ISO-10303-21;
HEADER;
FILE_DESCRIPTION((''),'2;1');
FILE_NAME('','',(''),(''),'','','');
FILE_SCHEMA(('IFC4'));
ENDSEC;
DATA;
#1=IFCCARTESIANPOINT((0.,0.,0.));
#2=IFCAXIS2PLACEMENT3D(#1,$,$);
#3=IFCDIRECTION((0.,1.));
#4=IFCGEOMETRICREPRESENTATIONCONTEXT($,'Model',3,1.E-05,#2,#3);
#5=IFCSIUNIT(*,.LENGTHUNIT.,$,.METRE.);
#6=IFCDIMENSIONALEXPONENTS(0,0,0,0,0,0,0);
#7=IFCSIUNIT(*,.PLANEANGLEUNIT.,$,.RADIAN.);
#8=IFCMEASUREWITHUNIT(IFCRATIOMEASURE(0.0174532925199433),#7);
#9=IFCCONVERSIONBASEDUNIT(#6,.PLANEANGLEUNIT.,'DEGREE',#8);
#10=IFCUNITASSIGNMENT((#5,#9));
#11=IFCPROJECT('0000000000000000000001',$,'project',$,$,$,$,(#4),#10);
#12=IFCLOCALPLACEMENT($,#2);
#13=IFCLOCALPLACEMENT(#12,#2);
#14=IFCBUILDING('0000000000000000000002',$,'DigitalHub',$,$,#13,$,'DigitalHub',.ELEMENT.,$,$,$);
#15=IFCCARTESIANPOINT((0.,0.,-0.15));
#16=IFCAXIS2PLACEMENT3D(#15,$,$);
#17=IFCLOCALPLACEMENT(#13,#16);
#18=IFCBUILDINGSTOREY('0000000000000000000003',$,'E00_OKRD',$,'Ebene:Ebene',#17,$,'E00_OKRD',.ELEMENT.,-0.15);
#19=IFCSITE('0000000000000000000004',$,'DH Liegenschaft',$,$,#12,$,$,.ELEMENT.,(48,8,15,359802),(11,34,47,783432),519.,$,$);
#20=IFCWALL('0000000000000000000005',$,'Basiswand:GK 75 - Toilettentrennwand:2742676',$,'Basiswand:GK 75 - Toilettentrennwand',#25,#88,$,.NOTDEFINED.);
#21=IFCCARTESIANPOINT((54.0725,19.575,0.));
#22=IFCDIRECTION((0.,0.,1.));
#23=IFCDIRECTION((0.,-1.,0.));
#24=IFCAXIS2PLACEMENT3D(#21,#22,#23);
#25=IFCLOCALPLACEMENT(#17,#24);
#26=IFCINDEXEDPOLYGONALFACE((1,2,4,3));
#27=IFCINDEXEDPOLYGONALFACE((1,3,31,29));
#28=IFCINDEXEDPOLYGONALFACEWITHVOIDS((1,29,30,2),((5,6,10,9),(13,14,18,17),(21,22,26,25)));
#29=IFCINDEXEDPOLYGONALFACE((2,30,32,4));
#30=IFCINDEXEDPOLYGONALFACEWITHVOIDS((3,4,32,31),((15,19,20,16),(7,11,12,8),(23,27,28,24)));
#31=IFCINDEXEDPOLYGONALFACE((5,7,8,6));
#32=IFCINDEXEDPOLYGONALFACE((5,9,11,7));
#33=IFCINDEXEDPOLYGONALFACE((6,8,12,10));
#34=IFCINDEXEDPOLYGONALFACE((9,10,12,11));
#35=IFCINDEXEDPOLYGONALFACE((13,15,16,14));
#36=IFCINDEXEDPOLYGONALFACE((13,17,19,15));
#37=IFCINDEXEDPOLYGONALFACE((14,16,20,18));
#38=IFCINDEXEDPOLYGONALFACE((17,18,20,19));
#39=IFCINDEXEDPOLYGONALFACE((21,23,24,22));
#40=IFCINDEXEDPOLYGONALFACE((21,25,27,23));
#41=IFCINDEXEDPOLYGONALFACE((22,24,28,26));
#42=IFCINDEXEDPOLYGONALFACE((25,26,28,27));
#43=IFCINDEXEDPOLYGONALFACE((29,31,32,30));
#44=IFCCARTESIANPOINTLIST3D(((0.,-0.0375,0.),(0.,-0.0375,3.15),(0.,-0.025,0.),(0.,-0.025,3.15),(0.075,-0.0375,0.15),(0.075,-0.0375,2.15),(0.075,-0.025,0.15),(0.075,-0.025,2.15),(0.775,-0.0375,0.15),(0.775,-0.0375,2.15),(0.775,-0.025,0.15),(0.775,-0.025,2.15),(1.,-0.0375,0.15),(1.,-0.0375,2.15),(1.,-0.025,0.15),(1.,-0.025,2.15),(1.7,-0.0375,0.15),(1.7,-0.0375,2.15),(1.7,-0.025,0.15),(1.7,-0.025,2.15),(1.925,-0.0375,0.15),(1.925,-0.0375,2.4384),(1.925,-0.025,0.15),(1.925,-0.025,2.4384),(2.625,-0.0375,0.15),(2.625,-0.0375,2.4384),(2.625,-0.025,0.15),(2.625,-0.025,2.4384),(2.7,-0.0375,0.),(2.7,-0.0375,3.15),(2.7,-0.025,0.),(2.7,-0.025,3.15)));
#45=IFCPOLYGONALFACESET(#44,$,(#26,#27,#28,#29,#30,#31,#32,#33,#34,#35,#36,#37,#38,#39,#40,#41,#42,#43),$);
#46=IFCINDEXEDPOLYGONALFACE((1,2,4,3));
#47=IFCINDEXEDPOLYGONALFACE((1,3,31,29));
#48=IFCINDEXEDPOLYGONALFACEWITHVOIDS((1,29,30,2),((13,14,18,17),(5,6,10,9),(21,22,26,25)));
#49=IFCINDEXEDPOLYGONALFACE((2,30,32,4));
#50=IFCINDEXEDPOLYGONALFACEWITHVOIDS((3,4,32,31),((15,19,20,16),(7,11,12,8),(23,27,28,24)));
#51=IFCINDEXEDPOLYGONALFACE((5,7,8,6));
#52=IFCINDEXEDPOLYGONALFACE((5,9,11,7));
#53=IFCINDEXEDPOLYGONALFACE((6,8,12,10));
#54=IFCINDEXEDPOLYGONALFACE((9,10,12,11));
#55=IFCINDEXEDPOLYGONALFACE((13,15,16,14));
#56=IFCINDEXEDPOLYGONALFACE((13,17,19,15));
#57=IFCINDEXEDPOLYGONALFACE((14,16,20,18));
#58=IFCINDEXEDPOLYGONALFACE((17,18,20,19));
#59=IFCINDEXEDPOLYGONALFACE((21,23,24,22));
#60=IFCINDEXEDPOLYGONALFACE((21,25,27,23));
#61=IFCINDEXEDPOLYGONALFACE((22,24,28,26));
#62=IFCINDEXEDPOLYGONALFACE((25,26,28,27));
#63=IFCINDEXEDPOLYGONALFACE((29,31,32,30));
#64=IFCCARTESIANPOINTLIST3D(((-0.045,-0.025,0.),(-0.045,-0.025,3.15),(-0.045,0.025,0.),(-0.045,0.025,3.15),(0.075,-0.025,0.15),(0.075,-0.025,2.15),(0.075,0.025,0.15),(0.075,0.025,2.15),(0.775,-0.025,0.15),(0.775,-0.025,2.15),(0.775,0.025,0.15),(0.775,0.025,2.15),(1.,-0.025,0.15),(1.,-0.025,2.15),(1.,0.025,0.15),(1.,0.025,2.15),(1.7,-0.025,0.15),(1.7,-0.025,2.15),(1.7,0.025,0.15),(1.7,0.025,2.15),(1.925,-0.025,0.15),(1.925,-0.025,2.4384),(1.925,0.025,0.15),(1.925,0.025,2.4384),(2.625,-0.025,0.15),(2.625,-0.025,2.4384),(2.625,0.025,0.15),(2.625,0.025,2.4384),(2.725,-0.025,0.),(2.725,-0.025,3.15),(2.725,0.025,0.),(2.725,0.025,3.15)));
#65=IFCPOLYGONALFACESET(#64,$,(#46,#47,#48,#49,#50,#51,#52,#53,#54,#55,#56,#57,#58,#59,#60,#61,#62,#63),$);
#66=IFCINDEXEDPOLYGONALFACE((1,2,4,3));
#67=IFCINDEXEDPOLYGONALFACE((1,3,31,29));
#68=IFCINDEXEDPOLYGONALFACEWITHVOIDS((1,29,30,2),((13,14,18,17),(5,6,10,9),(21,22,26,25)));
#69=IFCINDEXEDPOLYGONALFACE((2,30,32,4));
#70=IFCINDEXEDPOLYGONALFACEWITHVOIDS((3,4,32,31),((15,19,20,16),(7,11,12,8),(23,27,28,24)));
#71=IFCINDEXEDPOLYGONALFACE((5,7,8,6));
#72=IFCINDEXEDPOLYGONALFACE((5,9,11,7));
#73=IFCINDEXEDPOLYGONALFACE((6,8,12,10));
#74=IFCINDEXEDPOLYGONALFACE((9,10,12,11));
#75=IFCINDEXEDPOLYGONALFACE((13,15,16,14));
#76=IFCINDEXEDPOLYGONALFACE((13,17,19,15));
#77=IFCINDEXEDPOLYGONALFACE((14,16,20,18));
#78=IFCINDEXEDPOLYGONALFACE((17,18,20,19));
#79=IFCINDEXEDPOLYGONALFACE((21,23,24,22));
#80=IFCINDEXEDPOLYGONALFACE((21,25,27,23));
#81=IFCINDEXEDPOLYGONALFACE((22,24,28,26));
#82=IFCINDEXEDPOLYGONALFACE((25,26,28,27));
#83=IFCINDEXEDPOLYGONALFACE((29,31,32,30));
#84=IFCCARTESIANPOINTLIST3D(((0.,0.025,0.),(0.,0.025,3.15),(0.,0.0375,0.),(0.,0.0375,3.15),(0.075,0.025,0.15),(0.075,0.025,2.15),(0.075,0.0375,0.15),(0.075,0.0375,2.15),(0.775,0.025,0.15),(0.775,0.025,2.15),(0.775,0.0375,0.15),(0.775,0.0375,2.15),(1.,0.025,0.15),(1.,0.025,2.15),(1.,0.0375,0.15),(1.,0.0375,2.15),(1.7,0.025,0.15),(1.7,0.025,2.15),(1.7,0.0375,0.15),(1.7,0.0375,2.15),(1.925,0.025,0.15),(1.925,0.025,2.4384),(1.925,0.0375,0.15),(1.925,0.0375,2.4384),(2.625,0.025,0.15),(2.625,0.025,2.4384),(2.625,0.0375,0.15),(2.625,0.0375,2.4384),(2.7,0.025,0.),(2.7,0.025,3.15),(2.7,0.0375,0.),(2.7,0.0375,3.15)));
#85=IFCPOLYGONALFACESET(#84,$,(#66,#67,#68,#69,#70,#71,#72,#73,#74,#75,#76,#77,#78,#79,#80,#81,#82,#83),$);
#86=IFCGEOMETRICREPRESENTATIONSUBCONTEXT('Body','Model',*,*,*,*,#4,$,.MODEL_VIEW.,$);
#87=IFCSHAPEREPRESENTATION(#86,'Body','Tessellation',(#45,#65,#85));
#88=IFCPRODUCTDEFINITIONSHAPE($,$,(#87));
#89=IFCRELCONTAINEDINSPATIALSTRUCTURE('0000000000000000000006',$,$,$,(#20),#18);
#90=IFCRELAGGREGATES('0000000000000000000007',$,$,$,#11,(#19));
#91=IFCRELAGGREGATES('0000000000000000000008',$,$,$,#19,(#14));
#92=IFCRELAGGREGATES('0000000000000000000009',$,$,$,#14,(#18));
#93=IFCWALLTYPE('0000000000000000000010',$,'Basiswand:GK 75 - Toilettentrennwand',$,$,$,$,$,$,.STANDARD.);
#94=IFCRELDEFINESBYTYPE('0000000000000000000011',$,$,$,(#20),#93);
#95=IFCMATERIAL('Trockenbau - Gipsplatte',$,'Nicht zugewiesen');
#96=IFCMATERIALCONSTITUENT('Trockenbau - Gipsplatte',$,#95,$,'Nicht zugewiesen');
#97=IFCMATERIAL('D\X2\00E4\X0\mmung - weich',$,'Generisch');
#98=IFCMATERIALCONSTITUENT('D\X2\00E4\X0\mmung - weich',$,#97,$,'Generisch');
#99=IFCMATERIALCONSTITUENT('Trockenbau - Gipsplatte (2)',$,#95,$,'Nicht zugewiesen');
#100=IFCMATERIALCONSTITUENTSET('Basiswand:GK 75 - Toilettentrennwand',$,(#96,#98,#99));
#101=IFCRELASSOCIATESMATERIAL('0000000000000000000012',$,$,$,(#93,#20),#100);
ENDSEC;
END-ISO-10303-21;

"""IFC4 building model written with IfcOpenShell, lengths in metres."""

from ifc_helpers import new_model, entity, si_unit, converted_unit, direction, frame, origin, place, context, subcontext, project, spatial, indexed_curve, outline, extrude, material, constituent, constituent_set, type_object, element, save


model = new_model("IFC4")

# Units and contexts
model_context = context("Model", 3, precision=1e-05, world=origin(), true_north=direction((0.0, 1.0)))
body_context = subcontext(model_context, "Body", "Model", "MODEL_VIEW")
ifc_project = project(units=[si_unit("LENGTHUNIT", "METRE"), converted_unit("PLANEANGLEUNIT", "DEGREE", entity("IfcRatioMeasure", 0.0174532925199433), si_unit("PLANEANGLEUNIT", "RADIAN"), dimensions=[0, 0, 0, 0, 0, 0, 0])], contexts=[model_context])

# Site, building, storey
site_placement = place(None, frame((0.0, 0.0, 0.0)))
site = spatial("IfcSite", under=ifc_project, at=site_placement, Name="DH Liegenschaft", CompositionType="ELEMENT", RefLatitude=(48, 8, 15, 359802), RefLongitude=(11, 34, 47, 783432), RefElevation=519.0)
building_placement = place(site_placement, origin())
building = spatial("IfcBuilding", under=site, at=building_placement, Name="DigitalHub", LongName="DigitalHub", CompositionType="ELEMENT")
storey_placement = place(building_placement, frame((0.0, 0.0, -0.15)))
storey = spatial("IfcBuildingStorey", under=building, at=storey_placement, Name="E00_OKRD", ObjectType="Ebene:Ebene", LongName="E00_OKRD", CompositionType="ELEMENT", Elevation=-0.15)

# Shared definitions
ifc_material_1 = material(Name="Trockenbau - Gipsplatte", Category="Nicht zugewiesen")
ifc_material_2 = material(Name="Dämmung - weich", Category="Generisch")
ifc_constituent_1 = constituent(ifc_material_1, Name="Trockenbau - Gipsplatte", Category="Nicht zugewiesen")
ifc_constituent_2 = constituent(ifc_material_2, Name="Dämmung - weich", Category="Generisch")
ifc_constituent_3 = constituent(ifc_material_1, Name="Trockenbau - Gipsplatte (2)", Category="Nicht zugewiesen")
ifc_constituent_set_1 = constituent_set(constituents=[ifc_constituent_1, ifc_constituent_2, ifc_constituent_3], Name="Basiswand:GK 75 - Toilettentrennwand")
wall_type_1 = type_object("IfcWallType", Name="Basiswand:GK 75 - Toilettentrennwand", PredefinedType="STANDARD", material=ifc_constituent_set_1)

# Wall, openings
wall_1_placement = place(storey_placement, frame((54.0725, 19.575, 0.0), z_axis=(0.0, 0.0, 1.0), x_axis=(0.0, -1.0, 0.0)))
wall_1 = element("IfcWall", 1, at=wall_1_placement, inside=storey, type_object=wall_type_1, material=ifc_constituent_set_1, Name="Basiswand:GK 75 - Toilettentrennwand:2742676", ObjectType="Basiswand:GK 75 - Toilettentrennwand", PredefinedType="NOTDEFINED", context=body_context, shape_type="SweptSolid", body=[
    extrude(outline(indexed_curve([(-1.575, -1.35), (1.575, -1.35), (1.575, 1.35), (-1.575, 1.35), (-1.575, -1.35)], self_intersect=False), holes=[indexed_curve([(0.575, -1.275), (-1.425, -1.275), (-1.425, -0.575), (0.575, -0.575), (0.575, -1.275)], self_intersect=False), indexed_curve([(0.575, -0.35), (-1.425, -0.35), (-1.425, 0.35), (0.575, 0.35), (0.575, -0.35)], self_intersect=False), indexed_curve([(0.8634, 0.575), (-1.425, 0.575), (-1.425, 1.275), (0.8634, 1.275), (0.8634, 0.575)], self_intersect=False)]), frame((1.35, -0.0375, 1.575), z_axis=(0.0, 1.0, 0.0), x_axis=(0.0, 0.0, 1.0)), (0.0, 0.0, 1.0), 0.0125),
    extrude(outline(indexed_curve([(-1.575, -1.385), (1.575, -1.385), (1.575, 1.385), (-1.575, 1.385), (-1.575, -1.385)], self_intersect=False), holes=[indexed_curve([(0.8634, 0.585), (-1.425, 0.585), (-1.425, 1.285), (0.8634, 1.285), (0.8634, 0.585)], self_intersect=False), indexed_curve([(0.575, -0.34), (-1.425, -0.34), (-1.425, 0.36), (0.575, 0.36), (0.575, -0.34)], self_intersect=False), indexed_curve([(0.575, -1.265), (-1.425, -1.265), (-1.425, -0.565), (0.575, -0.565), (0.575, -1.265)], self_intersect=False)]), frame((1.34, -0.025, 1.575), z_axis=(0.0, 1.0, 0.0), x_axis=(0.0, 0.0, 1.0)), (0.0, 0.0, 1.0), 0.05),
    extrude(outline(indexed_curve([(-1.575, -1.35), (1.575, -1.35), (1.575, 1.35), (-1.575, 1.35), (-1.575, -1.35)], self_intersect=False), holes=[indexed_curve([(0.8634, 0.575), (-1.425, 0.575), (-1.425, 1.275), (0.8634, 1.275), (0.8634, 0.575)], self_intersect=False), indexed_curve([(0.575, -0.35), (-1.425, -0.35), (-1.425, 0.35), (0.575, 0.35), (0.575, -0.35)], self_intersect=False), indexed_curve([(0.575, -1.275), (-1.425, -1.275), (-1.425, -0.575), (0.575, -0.575), (0.575, -1.275)], self_intersect=False)]), frame((1.35, 0.025, 1.575), z_axis=(0.0, 1.0, 0.0), x_axis=(0.0, 0.0, 1.0)), (0.0, 0.0, 1.0), 0.0125),
])
opening_1_placement = place(wall_1_placement, frame((0.775, -0.0375, 0.15)))
element("IfcOpeningElement", 2, at=opening_1_placement, cuts=wall_1, PredefinedType="OPENING", context=body_context, shape_type="SweptSolid", body=[
    extrude(outline(indexed_curve([(-1.0, -0.35), (1.0, -0.35), (1.0, 0.35), (-1.0, 0.35), (-1.0, -0.35)], self_intersect=False)), frame((-0.35, 0.0, 1.0), z_axis=(0.0, 1.0, 0.0), x_axis=(0.0, 0.0, -1.0)), (0.0, 0.0, 1.0), 0.075),
])
opening_2_placement = place(wall_1_placement, frame((1.7, -0.0375, 0.15)))
element("IfcOpeningElement", 3, at=opening_2_placement, cuts=wall_1, PredefinedType="OPENING", context=body_context, shape_type="SweptSolid", body=[
    extrude(outline(indexed_curve([(-1.0, -0.35), (1.0, -0.35), (1.0, 0.35), (-1.0, 0.35), (-1.0, -0.35)], self_intersect=False)), frame((-0.35, 0.0, 1.0), z_axis=(0.0, 1.0, 0.0), x_axis=(0.0, 0.0, -1.0)), (0.0, 0.0, 1.0), 0.075),
])
opening_3_placement = place(wall_1_placement, frame((2.625, -0.0375, 0.15)))
element("IfcOpeningElement", 4, at=opening_3_placement, cuts=wall_1, PredefinedType="OPENING", context=body_context, shape_type="SweptSolid", body=[
    extrude(outline(indexed_curve([(-1.1442, -0.35), (1.1442, -0.35), (1.1442, 0.35), (-1.1442, 0.35), (-1.1442, -0.35)], self_intersect=False)), frame((-0.35, 0.0, 1.1442), z_axis=(0.0, 1.0, 0.0), x_axis=(0.0, 0.0, -1.0)), (0.0, 0.0, 1.0), 0.075),
])

save(model, "model.ifc")
